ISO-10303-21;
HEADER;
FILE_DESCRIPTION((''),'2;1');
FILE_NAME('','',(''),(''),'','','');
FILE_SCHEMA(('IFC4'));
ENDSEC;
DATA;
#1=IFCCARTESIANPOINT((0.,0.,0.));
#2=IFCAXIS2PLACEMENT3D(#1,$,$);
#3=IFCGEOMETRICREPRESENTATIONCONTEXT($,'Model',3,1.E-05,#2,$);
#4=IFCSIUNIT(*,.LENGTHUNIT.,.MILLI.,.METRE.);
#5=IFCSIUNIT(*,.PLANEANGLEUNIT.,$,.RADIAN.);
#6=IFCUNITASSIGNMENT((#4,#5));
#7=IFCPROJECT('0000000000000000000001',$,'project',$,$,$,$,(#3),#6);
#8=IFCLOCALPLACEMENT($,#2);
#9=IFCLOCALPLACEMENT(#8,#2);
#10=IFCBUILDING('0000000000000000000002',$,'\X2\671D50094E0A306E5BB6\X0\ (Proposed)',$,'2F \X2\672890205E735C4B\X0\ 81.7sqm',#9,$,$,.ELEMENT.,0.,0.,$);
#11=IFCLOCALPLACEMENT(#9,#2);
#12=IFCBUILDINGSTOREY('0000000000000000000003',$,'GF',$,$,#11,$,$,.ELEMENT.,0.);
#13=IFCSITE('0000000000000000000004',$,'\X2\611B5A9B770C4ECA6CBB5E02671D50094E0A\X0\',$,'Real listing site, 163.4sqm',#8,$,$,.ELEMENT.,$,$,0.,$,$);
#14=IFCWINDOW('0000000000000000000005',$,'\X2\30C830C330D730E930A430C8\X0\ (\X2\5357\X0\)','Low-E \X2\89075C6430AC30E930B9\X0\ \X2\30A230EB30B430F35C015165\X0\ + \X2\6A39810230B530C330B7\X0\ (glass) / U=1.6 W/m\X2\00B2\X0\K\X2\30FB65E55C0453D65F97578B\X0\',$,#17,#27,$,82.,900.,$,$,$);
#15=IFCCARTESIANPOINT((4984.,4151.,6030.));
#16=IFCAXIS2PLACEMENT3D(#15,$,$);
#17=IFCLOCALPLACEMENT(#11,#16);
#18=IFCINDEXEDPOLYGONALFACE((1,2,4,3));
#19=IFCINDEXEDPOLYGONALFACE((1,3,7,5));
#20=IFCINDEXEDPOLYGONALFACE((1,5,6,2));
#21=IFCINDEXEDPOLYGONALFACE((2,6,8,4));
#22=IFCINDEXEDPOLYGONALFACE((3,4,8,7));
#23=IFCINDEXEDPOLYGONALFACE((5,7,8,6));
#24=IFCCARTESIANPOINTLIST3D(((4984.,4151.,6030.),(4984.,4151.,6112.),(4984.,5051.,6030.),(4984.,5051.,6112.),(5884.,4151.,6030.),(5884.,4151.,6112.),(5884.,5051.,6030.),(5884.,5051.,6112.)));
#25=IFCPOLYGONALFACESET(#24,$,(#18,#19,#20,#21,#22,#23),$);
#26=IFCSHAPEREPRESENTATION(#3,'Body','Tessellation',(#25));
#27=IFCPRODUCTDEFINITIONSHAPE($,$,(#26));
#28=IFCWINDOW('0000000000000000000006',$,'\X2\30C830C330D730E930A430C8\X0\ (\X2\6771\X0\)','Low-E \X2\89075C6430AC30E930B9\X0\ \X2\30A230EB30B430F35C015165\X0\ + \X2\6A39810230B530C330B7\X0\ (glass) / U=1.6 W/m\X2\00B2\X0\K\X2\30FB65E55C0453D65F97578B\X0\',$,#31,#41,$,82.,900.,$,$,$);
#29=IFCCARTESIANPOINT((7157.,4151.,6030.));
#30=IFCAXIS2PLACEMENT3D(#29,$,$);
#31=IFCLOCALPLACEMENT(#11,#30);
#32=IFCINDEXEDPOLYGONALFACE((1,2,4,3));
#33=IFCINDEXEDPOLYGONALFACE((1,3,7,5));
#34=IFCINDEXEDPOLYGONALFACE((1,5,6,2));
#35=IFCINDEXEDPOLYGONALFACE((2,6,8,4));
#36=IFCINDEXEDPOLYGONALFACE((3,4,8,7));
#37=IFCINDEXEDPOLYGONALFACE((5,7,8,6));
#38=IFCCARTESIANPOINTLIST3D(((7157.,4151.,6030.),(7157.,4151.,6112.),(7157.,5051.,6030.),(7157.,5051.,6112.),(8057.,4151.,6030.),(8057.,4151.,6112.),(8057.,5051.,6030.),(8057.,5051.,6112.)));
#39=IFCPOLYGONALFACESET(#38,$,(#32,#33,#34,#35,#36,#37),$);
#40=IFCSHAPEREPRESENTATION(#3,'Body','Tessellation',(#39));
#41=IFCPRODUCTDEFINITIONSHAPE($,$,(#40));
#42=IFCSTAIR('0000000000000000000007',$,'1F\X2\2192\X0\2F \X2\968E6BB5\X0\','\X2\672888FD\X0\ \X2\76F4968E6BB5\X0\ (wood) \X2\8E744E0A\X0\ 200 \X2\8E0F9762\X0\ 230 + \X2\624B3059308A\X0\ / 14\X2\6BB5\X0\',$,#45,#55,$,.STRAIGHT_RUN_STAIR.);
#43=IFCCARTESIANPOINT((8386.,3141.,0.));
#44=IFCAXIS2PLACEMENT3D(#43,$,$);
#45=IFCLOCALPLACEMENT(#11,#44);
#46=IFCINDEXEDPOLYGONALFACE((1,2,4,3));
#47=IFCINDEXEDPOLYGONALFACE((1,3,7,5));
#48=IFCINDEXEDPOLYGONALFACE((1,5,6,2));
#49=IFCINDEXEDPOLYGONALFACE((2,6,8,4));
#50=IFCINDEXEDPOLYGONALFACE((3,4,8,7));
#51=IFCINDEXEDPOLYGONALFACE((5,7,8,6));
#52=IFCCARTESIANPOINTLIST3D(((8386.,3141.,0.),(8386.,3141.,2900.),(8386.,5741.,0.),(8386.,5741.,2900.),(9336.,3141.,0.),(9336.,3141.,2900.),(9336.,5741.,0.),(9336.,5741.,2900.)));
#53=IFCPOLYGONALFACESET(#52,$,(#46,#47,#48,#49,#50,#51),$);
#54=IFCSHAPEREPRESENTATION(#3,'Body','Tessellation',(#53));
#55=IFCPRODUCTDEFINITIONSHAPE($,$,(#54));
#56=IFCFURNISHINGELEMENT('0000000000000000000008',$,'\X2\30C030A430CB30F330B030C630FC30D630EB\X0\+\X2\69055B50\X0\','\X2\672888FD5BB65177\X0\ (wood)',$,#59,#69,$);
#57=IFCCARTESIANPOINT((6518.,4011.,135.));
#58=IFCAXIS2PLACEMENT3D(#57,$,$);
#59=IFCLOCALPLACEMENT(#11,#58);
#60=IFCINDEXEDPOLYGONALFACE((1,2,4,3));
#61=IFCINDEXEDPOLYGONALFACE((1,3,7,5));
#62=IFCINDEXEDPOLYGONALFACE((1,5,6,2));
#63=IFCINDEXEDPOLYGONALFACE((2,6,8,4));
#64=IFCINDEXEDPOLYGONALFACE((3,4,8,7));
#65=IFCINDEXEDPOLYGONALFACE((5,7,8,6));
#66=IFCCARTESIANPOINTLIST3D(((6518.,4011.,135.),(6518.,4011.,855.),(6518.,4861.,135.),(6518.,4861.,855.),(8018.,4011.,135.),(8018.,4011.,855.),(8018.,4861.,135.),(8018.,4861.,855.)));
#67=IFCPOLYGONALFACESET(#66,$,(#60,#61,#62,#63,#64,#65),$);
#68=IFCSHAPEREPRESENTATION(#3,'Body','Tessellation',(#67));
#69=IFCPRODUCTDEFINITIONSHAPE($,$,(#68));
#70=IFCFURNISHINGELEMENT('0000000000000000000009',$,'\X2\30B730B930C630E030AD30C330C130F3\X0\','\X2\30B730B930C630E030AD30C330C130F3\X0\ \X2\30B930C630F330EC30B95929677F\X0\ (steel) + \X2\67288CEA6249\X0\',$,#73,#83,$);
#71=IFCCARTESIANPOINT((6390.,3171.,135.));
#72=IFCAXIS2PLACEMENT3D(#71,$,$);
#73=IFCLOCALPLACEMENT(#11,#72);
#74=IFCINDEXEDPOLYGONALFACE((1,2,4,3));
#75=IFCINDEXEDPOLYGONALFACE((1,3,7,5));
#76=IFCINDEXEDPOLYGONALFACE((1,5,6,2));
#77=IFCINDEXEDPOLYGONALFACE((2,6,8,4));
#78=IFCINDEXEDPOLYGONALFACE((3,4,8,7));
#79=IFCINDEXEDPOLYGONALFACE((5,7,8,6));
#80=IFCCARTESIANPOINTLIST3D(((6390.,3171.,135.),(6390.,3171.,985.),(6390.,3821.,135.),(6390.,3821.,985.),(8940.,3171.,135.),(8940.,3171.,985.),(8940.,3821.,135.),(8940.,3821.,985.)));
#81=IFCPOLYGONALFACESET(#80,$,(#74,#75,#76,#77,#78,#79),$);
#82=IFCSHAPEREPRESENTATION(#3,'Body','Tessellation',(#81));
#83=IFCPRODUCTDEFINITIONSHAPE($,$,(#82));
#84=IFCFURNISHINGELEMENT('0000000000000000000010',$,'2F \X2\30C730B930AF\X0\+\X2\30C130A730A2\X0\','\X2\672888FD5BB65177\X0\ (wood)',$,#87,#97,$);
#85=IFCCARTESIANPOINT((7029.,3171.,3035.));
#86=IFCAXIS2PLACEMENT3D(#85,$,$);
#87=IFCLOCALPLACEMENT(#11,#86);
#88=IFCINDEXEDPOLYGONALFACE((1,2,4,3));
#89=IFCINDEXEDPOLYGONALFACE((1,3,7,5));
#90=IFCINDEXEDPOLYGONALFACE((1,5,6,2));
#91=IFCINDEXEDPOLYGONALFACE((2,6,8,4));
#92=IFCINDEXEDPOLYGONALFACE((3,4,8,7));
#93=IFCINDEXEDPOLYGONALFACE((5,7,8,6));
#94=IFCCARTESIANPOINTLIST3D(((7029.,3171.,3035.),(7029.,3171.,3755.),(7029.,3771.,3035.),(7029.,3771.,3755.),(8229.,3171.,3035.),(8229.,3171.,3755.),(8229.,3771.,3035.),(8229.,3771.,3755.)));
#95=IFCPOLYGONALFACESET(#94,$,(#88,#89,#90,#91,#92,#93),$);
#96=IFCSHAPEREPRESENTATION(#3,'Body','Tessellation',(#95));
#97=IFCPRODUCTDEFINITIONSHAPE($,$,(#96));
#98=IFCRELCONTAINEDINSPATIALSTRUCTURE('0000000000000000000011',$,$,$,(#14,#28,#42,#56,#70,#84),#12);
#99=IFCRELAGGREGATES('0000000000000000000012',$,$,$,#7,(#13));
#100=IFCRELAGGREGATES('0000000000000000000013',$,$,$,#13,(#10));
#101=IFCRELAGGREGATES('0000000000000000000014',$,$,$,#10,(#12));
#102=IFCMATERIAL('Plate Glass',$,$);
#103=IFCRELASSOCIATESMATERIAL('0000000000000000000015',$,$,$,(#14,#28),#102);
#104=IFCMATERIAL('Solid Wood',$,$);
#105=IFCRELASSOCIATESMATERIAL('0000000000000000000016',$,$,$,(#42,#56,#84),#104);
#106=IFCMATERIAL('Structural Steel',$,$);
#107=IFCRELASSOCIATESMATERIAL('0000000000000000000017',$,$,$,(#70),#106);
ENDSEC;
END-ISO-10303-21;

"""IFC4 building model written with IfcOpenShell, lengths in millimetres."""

from ifc_helpers import new_model, si_unit, frame, frame_2d, origin, place, context, project, spatial, rectangle, extrude, material, element, save


model = new_model("IFC4")

# Units and contexts
model_context = context("Model", 3, precision=1e-05, world=origin())
ifc_project = project(units=[si_unit("LENGTHUNIT", "METRE", prefix="MILLI"), si_unit("PLANEANGLEUNIT", "RADIAN")], contexts=[model_context])

# Site, building, storey
site_placement = place(None, origin())
site = spatial("IfcSite", under=ifc_project, at=site_placement, Name="愛媛県今治市朝倉上", ObjectType="Real listing site, 163.4sqm", CompositionType="ELEMENT", RefElevation=0.0)
building_placement = place(site_placement, origin())
building = spatial("IfcBuilding", under=site, at=building_placement, Name="朝倉上の家 (Proposed)", ObjectType="2F 木造平屋 81.7sqm", CompositionType="ELEMENT", ElevationOfRefHeight=0.0, ElevationOfTerrain=0.0)
storey_placement = place(building_placement, origin())
storey = spatial("IfcBuildingStorey", under=building, at=storey_placement, Name="GF", CompositionType="ELEMENT", Elevation=0.0)

# Shared definitions
ifc_material_1 = material(Name="Solid Wood")

# Shared definitions
ifc_material_2 = material(Name="Plate Glass")

# Windows
window_1_placement = place(storey_placement, frame((4984.0, 4151.0, 6030.0)))
element("IfcWindow", 1, at=window_1_placement, inside=storey, material=ifc_material_2, Name="トップライト (南)", Description="Low-E 複層ガラス アルゴン封入 + 樹脂サッシ (glass) / U=1.6 W/m²K・日射取得型", OverallHeight=82.0, OverallWidth=900.0, context=model_context, shape_type="SweptSolid", body=[
    extrude(rectangle(XDim=900.0, YDim=900.0, at=frame_2d((450.0, 450.0))), frame((4984.0, 4151.0, 6030.0)), (0.0, 0.0, 1.0), 82.0),
])
window_2_placement = place(storey_placement, frame((7157.0, 4151.0, 6030.0)))
element("IfcWindow", 2, at=window_2_placement, inside=storey, material=ifc_material_2, Name="トップライト (東)", Description="Low-E 複層ガラス アルゴン封入 + 樹脂サッシ (glass) / U=1.6 W/m²K・日射取得型", OverallHeight=82.0, OverallWidth=900.0, context=model_context, shape_type="SweptSolid", body=[
    extrude(rectangle(XDim=900.0, YDim=900.0, at=frame_2d((450.0, 450.0))), frame((7157.0, 4151.0, 6030.0)), (0.0, 0.0, 1.0), 82.0),
])

# Stair
stair_placement = place(storey_placement, frame((8386.0, 3141.0, 0.0)))
element("IfcStair", 3, at=stair_placement, inside=storey, material=ifc_material_1, Name="1F→2F 階段", Description="木製 直階段 (wood) 蹴上 200 踏面 230 + 手すり / 14段", PredefinedType="STRAIGHT_RUN_STAIR", context=model_context, shape_type="SweptSolid", body=[
    extrude(rectangle(XDim=950.0, YDim=2600.0, at=frame_2d((475.0, 1300.0))), frame((8386.0, 3141.0, 0.0)), (0.0, 0.0, 1.0), 2900.0),
])

# Furnishing elements
furnishing_1_placement = place(storey_placement, frame((6518.0, 4011.0, 135.0)))
element("IfcFurnishingElement", 4, at=furnishing_1_placement, inside=storey, material=ifc_material_1, Name="ダイニングテーブル+椅子", Description="木製家具 (wood)", context=model_context, shape_type="SweptSolid", body=[
    extrude(rectangle(XDim=1500.0, YDim=850.0, at=frame_2d((750.0, 425.0))), frame((6518.0, 4011.0, 135.0)), (0.0, 0.0, 1.0), 720.0),
])
ifc_material_3 = material(Name="Structural Steel")
furnishing_2_placement = place(storey_placement, frame((6390.0, 3171.0, 135.0)))
element("IfcFurnishingElement", 5, at=furnishing_2_placement, inside=storey, material=ifc_material_3, Name="システムキッチン", Description="システムキッチン ステンレス天板 (steel) + 木質扉", context=model_context, shape_type="SweptSolid", body=[
    extrude(rectangle(XDim=2550.0, YDim=650.0, at=frame_2d((1275.0, 325.0))), frame((6390.0, 3171.0, 135.0)), (0.0, 0.0, 1.0), 850.0),
])
furnishing_3_placement = place(storey_placement, frame((7029.0, 3171.0, 3035.0)))
element("IfcFurnishingElement", 6, at=furnishing_3_placement, inside=storey, material=ifc_material_1, Name="2F デスク+チェア", Description="木製家具 (wood)", context=model_context, shape_type="SweptSolid", body=[
    extrude(rectangle(XDim=1200.0, YDim=600.0, at=frame_2d((600.0, 300.0))), frame((7029.0, 3171.0, 3035.0)), (0.0, 0.0, 1.0), 720.0),
])

save(model, "model.ifc")
